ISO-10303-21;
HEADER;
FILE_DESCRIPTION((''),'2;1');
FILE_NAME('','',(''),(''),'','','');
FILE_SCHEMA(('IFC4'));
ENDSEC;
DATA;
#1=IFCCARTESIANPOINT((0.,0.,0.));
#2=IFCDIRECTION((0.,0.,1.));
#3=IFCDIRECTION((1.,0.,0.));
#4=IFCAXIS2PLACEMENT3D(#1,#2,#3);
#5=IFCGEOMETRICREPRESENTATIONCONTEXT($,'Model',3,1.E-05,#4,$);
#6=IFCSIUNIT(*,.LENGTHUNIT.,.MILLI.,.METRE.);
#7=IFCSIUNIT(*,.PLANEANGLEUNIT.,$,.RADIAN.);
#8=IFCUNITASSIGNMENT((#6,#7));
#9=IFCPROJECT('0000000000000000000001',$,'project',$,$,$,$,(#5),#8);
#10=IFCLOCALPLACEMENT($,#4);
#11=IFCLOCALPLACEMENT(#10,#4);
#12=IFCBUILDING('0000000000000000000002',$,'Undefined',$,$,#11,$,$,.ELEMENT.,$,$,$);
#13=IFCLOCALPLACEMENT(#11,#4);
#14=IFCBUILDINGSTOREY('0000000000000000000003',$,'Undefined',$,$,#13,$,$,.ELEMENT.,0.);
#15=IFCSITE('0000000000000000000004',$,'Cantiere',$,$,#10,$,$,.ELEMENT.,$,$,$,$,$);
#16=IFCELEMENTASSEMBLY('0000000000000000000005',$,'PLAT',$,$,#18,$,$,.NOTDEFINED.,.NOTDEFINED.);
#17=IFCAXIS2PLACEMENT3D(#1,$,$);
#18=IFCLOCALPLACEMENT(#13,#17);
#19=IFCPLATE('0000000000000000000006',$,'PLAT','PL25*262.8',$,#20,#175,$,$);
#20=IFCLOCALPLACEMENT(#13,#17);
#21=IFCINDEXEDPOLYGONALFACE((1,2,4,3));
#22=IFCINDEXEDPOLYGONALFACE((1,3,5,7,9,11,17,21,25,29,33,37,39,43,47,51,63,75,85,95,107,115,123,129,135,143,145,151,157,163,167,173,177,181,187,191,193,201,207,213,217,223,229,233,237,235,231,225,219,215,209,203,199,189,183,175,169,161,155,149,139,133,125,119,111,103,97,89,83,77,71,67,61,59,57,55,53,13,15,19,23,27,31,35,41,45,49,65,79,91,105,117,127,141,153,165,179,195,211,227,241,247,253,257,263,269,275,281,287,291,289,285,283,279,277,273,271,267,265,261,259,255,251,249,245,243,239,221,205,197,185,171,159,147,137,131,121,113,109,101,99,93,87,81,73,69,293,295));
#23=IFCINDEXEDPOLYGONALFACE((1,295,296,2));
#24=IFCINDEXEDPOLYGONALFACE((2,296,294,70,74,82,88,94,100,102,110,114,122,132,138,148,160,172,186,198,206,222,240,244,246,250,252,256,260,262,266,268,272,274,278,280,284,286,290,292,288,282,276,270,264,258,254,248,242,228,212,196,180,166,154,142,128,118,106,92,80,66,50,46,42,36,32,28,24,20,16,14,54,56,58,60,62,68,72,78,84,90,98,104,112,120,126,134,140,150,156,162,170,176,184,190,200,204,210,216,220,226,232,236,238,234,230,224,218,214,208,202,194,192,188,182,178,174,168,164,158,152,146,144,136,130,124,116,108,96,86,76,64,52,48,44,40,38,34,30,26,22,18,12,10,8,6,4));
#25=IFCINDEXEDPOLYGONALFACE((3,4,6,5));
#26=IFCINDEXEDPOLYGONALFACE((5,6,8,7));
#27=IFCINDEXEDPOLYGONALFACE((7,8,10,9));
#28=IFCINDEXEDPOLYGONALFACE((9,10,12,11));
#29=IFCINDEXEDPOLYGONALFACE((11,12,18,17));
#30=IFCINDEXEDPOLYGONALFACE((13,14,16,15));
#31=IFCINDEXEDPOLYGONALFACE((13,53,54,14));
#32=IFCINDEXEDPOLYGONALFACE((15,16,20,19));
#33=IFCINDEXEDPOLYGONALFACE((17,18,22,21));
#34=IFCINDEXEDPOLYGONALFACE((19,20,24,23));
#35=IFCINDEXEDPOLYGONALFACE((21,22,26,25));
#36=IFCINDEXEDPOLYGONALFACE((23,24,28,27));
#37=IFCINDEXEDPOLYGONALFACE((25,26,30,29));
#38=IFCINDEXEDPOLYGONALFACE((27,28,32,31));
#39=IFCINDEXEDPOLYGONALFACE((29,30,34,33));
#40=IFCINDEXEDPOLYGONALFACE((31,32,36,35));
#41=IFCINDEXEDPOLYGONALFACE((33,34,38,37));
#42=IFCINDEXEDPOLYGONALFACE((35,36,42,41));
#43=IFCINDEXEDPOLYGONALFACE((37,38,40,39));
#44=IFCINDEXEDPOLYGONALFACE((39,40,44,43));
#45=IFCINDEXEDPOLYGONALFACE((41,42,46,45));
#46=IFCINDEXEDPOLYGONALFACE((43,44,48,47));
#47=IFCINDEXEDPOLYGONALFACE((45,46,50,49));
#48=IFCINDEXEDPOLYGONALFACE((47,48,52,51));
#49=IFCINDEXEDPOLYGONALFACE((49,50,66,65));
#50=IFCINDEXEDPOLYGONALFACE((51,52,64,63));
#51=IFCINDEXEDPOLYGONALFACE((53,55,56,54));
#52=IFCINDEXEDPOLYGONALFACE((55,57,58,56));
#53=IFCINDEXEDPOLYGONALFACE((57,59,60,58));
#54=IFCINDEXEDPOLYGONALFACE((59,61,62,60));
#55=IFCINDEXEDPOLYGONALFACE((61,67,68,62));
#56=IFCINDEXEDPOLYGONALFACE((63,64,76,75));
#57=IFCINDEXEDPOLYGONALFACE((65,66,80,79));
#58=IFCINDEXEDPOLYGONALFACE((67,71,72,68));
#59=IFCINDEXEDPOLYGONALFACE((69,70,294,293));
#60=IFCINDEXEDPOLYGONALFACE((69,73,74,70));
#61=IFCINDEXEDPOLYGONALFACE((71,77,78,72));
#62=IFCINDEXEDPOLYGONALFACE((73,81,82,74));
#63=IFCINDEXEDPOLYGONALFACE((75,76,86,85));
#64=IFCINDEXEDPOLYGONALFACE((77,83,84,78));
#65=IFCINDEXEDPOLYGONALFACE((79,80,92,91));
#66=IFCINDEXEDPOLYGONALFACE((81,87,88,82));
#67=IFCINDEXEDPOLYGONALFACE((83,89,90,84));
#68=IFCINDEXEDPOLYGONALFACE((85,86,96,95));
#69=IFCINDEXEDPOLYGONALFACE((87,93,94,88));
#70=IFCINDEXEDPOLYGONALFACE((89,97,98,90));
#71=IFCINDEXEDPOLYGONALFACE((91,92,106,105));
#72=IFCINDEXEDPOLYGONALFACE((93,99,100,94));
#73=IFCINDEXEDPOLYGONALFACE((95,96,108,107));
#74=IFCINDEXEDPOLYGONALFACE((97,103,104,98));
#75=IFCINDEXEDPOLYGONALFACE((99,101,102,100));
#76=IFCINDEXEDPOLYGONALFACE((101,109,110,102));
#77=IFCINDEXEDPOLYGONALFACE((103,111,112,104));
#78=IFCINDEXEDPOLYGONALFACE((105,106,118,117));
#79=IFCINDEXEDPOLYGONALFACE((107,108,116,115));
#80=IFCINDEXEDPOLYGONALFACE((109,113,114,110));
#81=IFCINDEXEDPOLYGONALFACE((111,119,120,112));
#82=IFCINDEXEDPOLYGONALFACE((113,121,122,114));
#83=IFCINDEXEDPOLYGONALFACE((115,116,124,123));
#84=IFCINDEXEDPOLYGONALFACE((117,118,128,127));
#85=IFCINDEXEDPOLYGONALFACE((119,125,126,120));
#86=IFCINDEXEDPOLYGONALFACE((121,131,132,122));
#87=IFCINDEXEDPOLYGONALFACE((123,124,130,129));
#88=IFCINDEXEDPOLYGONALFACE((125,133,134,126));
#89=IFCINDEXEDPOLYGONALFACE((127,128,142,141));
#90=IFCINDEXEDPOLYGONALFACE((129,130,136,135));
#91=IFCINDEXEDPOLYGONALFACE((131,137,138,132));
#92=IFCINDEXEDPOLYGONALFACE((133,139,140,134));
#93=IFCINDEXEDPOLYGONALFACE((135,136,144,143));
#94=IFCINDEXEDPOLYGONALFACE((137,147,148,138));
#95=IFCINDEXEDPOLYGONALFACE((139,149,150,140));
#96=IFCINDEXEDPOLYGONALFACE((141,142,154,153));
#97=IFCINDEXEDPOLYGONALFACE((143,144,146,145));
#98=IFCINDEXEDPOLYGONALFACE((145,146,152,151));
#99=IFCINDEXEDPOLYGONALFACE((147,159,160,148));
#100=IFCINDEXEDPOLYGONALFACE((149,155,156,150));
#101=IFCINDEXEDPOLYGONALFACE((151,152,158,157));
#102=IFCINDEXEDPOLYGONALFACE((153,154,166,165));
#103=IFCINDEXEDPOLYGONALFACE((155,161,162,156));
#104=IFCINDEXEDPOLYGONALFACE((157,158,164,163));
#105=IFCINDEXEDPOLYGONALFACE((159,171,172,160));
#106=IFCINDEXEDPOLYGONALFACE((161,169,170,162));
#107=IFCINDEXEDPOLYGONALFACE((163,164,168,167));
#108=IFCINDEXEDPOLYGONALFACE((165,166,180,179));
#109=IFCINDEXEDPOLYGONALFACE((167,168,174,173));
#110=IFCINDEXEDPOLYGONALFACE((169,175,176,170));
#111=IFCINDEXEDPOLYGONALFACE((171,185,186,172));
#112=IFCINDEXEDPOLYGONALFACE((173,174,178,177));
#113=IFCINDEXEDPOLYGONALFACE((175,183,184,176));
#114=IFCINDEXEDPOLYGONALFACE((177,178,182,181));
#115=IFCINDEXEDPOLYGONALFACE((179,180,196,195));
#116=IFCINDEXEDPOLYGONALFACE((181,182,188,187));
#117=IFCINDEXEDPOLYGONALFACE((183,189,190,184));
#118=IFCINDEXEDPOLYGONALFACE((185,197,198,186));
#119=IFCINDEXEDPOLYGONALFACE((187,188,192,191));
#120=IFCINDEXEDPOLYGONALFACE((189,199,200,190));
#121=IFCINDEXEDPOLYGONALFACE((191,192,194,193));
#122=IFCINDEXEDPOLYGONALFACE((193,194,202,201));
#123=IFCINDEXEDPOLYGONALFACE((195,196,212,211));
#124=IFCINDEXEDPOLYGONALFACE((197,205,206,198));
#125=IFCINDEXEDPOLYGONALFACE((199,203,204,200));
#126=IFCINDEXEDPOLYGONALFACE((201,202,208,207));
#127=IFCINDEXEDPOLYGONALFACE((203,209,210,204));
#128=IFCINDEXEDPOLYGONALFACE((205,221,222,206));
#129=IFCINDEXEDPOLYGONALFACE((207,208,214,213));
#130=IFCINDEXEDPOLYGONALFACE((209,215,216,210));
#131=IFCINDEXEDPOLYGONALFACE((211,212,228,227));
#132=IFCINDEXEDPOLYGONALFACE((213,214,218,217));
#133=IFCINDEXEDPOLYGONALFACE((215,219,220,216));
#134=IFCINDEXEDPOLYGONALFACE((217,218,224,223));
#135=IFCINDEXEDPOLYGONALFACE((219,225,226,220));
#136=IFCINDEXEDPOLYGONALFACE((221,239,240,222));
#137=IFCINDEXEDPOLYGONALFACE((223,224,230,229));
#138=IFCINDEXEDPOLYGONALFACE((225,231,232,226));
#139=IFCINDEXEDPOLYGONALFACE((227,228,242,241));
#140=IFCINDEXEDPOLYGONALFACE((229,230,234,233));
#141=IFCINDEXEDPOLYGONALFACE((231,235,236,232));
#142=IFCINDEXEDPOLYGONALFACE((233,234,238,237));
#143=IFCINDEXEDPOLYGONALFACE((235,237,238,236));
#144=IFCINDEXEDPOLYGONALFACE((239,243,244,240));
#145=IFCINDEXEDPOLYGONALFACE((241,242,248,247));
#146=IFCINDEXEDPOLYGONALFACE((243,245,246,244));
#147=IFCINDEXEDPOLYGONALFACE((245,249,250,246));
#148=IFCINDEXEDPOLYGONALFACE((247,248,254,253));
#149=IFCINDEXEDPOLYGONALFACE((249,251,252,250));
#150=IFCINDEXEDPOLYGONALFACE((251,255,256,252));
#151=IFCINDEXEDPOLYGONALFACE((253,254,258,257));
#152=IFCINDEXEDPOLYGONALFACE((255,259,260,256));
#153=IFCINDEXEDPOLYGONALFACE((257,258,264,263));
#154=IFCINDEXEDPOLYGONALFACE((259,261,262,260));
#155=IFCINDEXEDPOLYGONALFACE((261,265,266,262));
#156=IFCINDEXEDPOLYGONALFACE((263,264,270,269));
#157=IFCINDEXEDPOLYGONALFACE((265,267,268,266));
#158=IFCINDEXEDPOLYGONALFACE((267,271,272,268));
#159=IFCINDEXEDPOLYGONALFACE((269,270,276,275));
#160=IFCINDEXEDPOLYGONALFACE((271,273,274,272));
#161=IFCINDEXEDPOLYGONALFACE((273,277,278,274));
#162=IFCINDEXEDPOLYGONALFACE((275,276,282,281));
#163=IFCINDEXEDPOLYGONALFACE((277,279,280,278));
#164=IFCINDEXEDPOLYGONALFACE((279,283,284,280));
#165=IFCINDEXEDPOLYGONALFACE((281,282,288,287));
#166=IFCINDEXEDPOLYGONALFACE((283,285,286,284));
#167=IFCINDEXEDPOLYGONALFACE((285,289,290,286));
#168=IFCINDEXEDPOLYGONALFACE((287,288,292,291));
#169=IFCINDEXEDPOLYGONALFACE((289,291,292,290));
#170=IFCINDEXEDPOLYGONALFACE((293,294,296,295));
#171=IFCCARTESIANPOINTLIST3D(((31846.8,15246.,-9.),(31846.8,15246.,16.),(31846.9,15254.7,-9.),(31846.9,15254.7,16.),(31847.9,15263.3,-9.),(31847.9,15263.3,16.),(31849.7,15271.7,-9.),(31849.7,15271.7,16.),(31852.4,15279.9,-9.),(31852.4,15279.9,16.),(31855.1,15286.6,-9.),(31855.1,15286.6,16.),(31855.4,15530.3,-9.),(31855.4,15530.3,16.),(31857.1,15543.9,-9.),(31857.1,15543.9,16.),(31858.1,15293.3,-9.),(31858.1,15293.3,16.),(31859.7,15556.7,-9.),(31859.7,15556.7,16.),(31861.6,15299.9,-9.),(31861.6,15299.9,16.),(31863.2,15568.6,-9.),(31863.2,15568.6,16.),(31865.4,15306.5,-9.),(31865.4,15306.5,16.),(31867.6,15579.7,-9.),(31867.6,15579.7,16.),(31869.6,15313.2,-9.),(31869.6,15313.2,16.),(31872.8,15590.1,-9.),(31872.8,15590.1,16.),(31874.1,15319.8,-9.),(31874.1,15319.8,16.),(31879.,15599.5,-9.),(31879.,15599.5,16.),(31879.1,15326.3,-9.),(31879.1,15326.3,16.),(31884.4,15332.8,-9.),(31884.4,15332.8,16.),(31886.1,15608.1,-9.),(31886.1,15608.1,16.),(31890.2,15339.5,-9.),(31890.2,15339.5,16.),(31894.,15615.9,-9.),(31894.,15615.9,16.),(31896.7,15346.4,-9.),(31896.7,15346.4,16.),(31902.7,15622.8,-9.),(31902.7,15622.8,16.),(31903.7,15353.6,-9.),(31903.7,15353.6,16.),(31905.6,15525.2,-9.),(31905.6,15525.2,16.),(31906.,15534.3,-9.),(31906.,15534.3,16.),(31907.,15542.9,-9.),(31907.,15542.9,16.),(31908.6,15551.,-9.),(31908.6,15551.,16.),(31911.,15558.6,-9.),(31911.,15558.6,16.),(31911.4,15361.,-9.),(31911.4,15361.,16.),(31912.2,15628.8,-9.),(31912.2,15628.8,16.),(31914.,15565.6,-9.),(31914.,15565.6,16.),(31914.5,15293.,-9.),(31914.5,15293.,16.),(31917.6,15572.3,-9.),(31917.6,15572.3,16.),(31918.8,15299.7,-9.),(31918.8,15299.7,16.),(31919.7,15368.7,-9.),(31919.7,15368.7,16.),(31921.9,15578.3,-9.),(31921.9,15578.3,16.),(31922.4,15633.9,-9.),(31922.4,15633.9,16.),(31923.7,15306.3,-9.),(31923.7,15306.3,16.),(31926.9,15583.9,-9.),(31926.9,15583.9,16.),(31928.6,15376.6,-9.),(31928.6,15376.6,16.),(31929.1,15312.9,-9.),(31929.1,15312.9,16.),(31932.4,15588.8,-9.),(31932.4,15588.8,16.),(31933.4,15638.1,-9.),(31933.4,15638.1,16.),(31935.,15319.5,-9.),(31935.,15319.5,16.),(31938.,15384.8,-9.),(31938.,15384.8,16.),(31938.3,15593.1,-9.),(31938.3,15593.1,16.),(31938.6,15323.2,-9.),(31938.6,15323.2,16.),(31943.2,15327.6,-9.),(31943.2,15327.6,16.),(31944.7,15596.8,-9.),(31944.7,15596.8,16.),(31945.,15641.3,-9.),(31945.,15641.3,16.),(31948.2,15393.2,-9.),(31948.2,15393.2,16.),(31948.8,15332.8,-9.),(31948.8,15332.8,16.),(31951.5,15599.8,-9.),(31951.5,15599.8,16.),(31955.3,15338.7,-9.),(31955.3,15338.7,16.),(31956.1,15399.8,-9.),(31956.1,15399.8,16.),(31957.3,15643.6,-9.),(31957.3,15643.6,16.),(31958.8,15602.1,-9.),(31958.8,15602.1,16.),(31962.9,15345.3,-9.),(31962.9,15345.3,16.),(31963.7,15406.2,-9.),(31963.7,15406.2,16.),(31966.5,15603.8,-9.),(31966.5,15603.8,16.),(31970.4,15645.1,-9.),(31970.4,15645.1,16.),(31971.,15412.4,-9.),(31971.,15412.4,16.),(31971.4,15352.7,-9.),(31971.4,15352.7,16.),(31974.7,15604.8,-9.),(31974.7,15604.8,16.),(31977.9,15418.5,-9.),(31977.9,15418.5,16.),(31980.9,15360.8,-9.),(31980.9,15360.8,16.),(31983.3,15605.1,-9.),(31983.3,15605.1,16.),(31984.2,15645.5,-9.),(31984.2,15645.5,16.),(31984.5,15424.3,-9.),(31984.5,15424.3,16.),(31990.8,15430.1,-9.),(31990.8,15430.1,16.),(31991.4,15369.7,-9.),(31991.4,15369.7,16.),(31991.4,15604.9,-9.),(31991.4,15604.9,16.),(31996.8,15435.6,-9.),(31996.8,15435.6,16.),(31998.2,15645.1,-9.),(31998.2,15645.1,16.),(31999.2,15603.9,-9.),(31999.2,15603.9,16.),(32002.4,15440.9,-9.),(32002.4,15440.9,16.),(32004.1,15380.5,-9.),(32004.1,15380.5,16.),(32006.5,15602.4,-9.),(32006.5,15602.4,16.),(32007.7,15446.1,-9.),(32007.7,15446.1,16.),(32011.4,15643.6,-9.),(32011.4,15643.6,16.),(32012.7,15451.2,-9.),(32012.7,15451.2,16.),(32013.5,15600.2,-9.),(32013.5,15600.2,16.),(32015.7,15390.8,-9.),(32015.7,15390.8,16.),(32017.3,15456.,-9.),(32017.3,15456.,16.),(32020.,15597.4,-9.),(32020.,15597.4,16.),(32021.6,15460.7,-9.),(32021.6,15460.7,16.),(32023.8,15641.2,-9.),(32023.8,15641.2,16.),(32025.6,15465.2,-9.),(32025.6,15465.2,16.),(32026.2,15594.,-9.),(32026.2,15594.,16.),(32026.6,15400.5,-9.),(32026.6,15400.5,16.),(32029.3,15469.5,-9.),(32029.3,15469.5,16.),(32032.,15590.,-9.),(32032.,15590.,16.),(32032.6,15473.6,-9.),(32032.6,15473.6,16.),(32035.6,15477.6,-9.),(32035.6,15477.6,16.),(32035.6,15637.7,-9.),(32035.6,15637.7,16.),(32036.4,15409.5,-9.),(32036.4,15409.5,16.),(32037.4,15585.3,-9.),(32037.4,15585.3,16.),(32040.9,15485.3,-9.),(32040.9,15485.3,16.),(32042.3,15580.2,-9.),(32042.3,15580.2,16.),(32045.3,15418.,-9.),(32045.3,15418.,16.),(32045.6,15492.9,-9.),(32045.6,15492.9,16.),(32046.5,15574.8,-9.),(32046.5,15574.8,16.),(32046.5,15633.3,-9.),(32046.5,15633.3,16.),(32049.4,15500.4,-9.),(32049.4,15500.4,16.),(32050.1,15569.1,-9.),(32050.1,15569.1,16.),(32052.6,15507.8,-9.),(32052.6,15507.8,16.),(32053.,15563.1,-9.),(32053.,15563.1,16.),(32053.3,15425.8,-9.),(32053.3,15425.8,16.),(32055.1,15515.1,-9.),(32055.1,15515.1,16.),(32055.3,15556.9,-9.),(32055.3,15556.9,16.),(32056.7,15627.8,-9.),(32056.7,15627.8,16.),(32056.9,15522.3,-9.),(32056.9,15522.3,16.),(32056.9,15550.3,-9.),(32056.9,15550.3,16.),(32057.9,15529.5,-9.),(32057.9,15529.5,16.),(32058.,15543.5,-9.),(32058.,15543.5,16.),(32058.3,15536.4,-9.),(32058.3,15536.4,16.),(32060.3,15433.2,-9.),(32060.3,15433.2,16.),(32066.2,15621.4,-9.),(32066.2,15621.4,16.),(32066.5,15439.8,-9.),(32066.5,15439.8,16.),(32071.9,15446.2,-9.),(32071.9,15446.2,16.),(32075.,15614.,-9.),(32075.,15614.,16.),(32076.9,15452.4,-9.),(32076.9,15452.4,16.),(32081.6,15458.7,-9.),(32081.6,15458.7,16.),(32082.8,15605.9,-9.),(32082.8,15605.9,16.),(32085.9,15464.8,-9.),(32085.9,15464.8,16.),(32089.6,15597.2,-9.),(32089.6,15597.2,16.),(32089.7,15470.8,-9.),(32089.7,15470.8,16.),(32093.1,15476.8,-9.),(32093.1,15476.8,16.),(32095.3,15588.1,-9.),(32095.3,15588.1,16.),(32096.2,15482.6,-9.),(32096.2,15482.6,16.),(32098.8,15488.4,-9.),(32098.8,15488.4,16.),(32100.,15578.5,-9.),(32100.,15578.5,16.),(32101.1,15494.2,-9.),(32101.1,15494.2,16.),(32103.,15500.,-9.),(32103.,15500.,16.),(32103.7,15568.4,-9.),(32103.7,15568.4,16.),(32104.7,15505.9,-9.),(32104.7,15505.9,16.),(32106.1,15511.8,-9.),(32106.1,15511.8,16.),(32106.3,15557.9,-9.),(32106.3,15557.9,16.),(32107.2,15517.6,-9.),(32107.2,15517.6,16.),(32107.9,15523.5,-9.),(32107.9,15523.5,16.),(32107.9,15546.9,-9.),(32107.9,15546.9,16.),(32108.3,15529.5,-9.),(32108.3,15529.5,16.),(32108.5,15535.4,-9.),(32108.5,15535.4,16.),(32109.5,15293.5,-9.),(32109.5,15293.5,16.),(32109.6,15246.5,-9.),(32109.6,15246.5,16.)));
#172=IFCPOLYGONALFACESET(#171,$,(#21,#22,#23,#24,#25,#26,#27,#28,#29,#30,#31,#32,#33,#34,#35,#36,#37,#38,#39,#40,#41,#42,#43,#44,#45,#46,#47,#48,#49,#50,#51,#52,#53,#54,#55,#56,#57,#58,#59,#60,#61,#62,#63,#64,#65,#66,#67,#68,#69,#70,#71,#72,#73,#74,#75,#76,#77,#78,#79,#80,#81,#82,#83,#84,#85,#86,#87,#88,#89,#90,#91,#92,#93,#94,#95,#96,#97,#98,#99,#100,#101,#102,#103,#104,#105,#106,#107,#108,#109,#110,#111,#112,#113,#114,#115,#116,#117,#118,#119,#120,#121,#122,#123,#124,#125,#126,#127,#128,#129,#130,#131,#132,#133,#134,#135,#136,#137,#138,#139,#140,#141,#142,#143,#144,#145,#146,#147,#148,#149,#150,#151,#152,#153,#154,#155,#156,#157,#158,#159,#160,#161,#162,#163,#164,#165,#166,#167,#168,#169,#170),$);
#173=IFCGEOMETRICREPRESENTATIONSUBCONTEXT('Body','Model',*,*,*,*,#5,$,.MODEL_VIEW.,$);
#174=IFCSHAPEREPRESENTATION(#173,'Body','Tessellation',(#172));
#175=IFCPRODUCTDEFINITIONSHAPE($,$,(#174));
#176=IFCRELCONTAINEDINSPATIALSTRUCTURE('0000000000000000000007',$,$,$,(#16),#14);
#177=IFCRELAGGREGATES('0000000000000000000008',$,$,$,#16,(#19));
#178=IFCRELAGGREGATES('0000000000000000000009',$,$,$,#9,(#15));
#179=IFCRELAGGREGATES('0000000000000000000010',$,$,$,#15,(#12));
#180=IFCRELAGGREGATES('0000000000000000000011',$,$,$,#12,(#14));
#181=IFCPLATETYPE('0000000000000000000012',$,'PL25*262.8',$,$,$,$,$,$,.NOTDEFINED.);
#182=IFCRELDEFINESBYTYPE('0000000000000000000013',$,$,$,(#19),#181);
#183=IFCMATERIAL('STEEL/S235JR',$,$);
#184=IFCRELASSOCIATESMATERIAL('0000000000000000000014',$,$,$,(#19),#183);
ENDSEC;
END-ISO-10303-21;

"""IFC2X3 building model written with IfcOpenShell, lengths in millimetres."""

from ifc_helpers import new_model, si_unit, frame, origin_with_axes, place, context, subcontext, project, spatial, polyline, outline, extrude, material, type_object, element, aggregate, save


model = new_model("IFC2X3")

# Units and contexts
model_context = context("Model", 3, precision=1e-05, world=origin_with_axes())
body_context = subcontext(model_context, "Body", "Model", "MODEL_VIEW")
ifc_project = project(units=[si_unit("LENGTHUNIT", "METRE", prefix="MILLI"), si_unit("PLANEANGLEUNIT", "RADIAN")], contexts=[model_context])

# Site, building, storey
site_placement = place(None, origin_with_axes())
site = spatial("IfcSite", under=ifc_project, at=site_placement, Name="Cantiere", CompositionType="ELEMENT")
building_placement = place(site_placement, origin_with_axes())
building = spatial("IfcBuilding", under=site, at=building_placement, Name="Undefined", CompositionType="ELEMENT")
storey_placement = place(building_placement, origin_with_axes())
storey = spatial("IfcBuildingStorey", under=building, at=storey_placement, Name="Undefined", CompositionType="ELEMENT", Elevation=0.0)

# Element assembly, plate
ifc_material_1 = material(Name="STEEL/S235JR")
assembly_1_placement = place(storey_placement, origin_with_axes())
assembly_1 = element("IfcElementAssembly", 1, at=assembly_1_placement, inside=storey, Name="PLAT", AssemblyPlace="NOTDEFINED", PredefinedType="NOTDEFINED")
plate_type_1 = type_object("IfcPlateType", Name="PL25*262.8", PredefinedType="NOTDEFINED")
plate_1_placement = place(assembly_1_placement, frame((32109.5, 15293.5, 3.5), z_axis=(0.0, 0.000001, -1.0), x_axis=(0.00212, -0.999998, 0.0)))
plate_1 = element("IfcPlate", 2, at=plate_1_placement, type_object=plate_type_1, material=ifc_material_1, Name="PLAT", Description="PL25*262.8", context=body_context, shape_type="SweptSolid", body=[
    extrude(outline(polyline([(0.0, 0.0), (46.9, 0.0), (46.9, 262.8), (38.2, 262.7), (29.6, 261.7), (21.3, 259.9), (13.0, 257.2), (6.3, 254.5), (-0.4, 251.4), (-7.0, 247.9), (-13.6, 244.1), (-20.2, 239.9), (-26.8, 235.3), (-33.4, 230.4), (-39.9, 225.0), (-46.5, 219.2), (-53.4, 212.7), (-60.6, 205.7), (-68.0, 198.0), (-75.6, 189.7), (-83.5, 180.8), (-91.7, 171.3), (-100.1, 161.1), (-106.7, 153.2), (-113.1, 145.6), (-119.3, 138.3), (-125.3, 131.3), (-131.2, 124.7), (-136.9, 118.4), (-142.4, 112.5), (-147.7, 106.8), (-152.9, 101.5), (-157.9, 96.5), (-162.8, 91.9), (-167.4, 87.5), (-171.9, 83.5), (-176.2, 79.9), (-180.4, 76.5), (-184.3, 73.5), (-192.0, 68.2), (-199.6, 63.5), (-207.1, 59.6), (-214.5, 56.5), (-221.8, 54.0), (-229.0, 52.1), (-236.1, 51.1), (-243.1, 50.7), (-250.2, 51.0), (-257.0, 52.0), (-263.6, 53.6), (-269.8, 56.0), (-275.8, 58.8), (-281.5, 62.4), (-286.9, 66.6), (-292.0, 71.5), (-296.7, 76.9), (-300.8, 82.6), (-304.2, 88.8), (-307.0, 95.4), (-309.2, 102.3), (-310.7, 109.7), (-311.7, 117.5), (-312.0, 125.6), (-311.6, 134.2), (-310.7, 142.3), (-309.0, 150.0), (-306.7, 157.3), (-303.7, 164.2), (-300.1, 170.6), (-295.8, 176.5), (-290.8, 182.0), (-285.3, 187.0), (-279.2, 191.3), (-272.6, 195.0), (-265.6, 198.0), (-258.0, 200.3), (-249.9, 202.0), (-241.3, 203.0), (-232.2, 203.4), (-237.4, 253.6), (-251.0, 251.9), (-263.8, 249.3), (-275.7, 245.8), (-286.8, 241.3), (-297.1, 236.1), (-306.5, 229.9), (-315.2, 222.8), (-322.9, 214.8), (-329.8, 206.1), (-335.8, 196.6), (-340.9, 186.4), (-345.0, 175.4), (-348.2, 163.8), (-350.5, 151.4), (-351.9, 138.3), (-352.4, 124.5), (-351.9, 110.6), (-350.4, 97.4), (-347.9, 85.0), (-344.4, 73.2), (-340.0, 62.3), (-334.5, 52.1), (-328.1, 42.6), (-320.6, 33.9), (-312.5, 26.1), (-303.8, 19.3), (-294.7, 13.6), (-285.1, 8.9), (-275.0, 5.2), (-264.5, 2.6), (-253.5, 1.0), (-242.0, 0.5), (-236.0, 0.7), (-230.1, 1.1), (-224.2, 1.9), (-218.3, 3.0), (-212.5, 4.3), (-206.6, 6.0), (-200.8, 8.0), (-195.0, 10.3), (-189.2, 13.0), (-183.4, 16.0), (-177.4, 19.5), (-171.4, 23.3), (-165.3, 27.5), (-159.1, 32.2), (-152.8, 37.3), (-146.5, 42.7), (-139.8, 48.9), (-132.5, 56.0), (-124.7, 64.0), (-116.2, 72.9), (-107.2, 82.7), (-97.6, 93.6), (-87.3, 105.3), (-76.5, 118.0), (-67.7, 128.5), (-59.6, 138.0), (-52.2, 146.5), (-45.5, 154.1), (-39.7, 160.6), (-34.5, 166.2), (-30.1, 170.8), (-26.5, 174.4), (-19.9, 180.4), (-13.2, 185.8), (-6.7, 190.7), (0.0, 195.0), (0.0, 0.0)])), frame((0.0, 0.0, -12.5), z_axis=(0.0, 0.0, 1.0), x_axis=(1.0, 0.0, 0.0)), (0.0, 0.0, 1.0), 25.0),
])
aggregate(assembly_1, [plate_1])

save(model, "model.ifc")
